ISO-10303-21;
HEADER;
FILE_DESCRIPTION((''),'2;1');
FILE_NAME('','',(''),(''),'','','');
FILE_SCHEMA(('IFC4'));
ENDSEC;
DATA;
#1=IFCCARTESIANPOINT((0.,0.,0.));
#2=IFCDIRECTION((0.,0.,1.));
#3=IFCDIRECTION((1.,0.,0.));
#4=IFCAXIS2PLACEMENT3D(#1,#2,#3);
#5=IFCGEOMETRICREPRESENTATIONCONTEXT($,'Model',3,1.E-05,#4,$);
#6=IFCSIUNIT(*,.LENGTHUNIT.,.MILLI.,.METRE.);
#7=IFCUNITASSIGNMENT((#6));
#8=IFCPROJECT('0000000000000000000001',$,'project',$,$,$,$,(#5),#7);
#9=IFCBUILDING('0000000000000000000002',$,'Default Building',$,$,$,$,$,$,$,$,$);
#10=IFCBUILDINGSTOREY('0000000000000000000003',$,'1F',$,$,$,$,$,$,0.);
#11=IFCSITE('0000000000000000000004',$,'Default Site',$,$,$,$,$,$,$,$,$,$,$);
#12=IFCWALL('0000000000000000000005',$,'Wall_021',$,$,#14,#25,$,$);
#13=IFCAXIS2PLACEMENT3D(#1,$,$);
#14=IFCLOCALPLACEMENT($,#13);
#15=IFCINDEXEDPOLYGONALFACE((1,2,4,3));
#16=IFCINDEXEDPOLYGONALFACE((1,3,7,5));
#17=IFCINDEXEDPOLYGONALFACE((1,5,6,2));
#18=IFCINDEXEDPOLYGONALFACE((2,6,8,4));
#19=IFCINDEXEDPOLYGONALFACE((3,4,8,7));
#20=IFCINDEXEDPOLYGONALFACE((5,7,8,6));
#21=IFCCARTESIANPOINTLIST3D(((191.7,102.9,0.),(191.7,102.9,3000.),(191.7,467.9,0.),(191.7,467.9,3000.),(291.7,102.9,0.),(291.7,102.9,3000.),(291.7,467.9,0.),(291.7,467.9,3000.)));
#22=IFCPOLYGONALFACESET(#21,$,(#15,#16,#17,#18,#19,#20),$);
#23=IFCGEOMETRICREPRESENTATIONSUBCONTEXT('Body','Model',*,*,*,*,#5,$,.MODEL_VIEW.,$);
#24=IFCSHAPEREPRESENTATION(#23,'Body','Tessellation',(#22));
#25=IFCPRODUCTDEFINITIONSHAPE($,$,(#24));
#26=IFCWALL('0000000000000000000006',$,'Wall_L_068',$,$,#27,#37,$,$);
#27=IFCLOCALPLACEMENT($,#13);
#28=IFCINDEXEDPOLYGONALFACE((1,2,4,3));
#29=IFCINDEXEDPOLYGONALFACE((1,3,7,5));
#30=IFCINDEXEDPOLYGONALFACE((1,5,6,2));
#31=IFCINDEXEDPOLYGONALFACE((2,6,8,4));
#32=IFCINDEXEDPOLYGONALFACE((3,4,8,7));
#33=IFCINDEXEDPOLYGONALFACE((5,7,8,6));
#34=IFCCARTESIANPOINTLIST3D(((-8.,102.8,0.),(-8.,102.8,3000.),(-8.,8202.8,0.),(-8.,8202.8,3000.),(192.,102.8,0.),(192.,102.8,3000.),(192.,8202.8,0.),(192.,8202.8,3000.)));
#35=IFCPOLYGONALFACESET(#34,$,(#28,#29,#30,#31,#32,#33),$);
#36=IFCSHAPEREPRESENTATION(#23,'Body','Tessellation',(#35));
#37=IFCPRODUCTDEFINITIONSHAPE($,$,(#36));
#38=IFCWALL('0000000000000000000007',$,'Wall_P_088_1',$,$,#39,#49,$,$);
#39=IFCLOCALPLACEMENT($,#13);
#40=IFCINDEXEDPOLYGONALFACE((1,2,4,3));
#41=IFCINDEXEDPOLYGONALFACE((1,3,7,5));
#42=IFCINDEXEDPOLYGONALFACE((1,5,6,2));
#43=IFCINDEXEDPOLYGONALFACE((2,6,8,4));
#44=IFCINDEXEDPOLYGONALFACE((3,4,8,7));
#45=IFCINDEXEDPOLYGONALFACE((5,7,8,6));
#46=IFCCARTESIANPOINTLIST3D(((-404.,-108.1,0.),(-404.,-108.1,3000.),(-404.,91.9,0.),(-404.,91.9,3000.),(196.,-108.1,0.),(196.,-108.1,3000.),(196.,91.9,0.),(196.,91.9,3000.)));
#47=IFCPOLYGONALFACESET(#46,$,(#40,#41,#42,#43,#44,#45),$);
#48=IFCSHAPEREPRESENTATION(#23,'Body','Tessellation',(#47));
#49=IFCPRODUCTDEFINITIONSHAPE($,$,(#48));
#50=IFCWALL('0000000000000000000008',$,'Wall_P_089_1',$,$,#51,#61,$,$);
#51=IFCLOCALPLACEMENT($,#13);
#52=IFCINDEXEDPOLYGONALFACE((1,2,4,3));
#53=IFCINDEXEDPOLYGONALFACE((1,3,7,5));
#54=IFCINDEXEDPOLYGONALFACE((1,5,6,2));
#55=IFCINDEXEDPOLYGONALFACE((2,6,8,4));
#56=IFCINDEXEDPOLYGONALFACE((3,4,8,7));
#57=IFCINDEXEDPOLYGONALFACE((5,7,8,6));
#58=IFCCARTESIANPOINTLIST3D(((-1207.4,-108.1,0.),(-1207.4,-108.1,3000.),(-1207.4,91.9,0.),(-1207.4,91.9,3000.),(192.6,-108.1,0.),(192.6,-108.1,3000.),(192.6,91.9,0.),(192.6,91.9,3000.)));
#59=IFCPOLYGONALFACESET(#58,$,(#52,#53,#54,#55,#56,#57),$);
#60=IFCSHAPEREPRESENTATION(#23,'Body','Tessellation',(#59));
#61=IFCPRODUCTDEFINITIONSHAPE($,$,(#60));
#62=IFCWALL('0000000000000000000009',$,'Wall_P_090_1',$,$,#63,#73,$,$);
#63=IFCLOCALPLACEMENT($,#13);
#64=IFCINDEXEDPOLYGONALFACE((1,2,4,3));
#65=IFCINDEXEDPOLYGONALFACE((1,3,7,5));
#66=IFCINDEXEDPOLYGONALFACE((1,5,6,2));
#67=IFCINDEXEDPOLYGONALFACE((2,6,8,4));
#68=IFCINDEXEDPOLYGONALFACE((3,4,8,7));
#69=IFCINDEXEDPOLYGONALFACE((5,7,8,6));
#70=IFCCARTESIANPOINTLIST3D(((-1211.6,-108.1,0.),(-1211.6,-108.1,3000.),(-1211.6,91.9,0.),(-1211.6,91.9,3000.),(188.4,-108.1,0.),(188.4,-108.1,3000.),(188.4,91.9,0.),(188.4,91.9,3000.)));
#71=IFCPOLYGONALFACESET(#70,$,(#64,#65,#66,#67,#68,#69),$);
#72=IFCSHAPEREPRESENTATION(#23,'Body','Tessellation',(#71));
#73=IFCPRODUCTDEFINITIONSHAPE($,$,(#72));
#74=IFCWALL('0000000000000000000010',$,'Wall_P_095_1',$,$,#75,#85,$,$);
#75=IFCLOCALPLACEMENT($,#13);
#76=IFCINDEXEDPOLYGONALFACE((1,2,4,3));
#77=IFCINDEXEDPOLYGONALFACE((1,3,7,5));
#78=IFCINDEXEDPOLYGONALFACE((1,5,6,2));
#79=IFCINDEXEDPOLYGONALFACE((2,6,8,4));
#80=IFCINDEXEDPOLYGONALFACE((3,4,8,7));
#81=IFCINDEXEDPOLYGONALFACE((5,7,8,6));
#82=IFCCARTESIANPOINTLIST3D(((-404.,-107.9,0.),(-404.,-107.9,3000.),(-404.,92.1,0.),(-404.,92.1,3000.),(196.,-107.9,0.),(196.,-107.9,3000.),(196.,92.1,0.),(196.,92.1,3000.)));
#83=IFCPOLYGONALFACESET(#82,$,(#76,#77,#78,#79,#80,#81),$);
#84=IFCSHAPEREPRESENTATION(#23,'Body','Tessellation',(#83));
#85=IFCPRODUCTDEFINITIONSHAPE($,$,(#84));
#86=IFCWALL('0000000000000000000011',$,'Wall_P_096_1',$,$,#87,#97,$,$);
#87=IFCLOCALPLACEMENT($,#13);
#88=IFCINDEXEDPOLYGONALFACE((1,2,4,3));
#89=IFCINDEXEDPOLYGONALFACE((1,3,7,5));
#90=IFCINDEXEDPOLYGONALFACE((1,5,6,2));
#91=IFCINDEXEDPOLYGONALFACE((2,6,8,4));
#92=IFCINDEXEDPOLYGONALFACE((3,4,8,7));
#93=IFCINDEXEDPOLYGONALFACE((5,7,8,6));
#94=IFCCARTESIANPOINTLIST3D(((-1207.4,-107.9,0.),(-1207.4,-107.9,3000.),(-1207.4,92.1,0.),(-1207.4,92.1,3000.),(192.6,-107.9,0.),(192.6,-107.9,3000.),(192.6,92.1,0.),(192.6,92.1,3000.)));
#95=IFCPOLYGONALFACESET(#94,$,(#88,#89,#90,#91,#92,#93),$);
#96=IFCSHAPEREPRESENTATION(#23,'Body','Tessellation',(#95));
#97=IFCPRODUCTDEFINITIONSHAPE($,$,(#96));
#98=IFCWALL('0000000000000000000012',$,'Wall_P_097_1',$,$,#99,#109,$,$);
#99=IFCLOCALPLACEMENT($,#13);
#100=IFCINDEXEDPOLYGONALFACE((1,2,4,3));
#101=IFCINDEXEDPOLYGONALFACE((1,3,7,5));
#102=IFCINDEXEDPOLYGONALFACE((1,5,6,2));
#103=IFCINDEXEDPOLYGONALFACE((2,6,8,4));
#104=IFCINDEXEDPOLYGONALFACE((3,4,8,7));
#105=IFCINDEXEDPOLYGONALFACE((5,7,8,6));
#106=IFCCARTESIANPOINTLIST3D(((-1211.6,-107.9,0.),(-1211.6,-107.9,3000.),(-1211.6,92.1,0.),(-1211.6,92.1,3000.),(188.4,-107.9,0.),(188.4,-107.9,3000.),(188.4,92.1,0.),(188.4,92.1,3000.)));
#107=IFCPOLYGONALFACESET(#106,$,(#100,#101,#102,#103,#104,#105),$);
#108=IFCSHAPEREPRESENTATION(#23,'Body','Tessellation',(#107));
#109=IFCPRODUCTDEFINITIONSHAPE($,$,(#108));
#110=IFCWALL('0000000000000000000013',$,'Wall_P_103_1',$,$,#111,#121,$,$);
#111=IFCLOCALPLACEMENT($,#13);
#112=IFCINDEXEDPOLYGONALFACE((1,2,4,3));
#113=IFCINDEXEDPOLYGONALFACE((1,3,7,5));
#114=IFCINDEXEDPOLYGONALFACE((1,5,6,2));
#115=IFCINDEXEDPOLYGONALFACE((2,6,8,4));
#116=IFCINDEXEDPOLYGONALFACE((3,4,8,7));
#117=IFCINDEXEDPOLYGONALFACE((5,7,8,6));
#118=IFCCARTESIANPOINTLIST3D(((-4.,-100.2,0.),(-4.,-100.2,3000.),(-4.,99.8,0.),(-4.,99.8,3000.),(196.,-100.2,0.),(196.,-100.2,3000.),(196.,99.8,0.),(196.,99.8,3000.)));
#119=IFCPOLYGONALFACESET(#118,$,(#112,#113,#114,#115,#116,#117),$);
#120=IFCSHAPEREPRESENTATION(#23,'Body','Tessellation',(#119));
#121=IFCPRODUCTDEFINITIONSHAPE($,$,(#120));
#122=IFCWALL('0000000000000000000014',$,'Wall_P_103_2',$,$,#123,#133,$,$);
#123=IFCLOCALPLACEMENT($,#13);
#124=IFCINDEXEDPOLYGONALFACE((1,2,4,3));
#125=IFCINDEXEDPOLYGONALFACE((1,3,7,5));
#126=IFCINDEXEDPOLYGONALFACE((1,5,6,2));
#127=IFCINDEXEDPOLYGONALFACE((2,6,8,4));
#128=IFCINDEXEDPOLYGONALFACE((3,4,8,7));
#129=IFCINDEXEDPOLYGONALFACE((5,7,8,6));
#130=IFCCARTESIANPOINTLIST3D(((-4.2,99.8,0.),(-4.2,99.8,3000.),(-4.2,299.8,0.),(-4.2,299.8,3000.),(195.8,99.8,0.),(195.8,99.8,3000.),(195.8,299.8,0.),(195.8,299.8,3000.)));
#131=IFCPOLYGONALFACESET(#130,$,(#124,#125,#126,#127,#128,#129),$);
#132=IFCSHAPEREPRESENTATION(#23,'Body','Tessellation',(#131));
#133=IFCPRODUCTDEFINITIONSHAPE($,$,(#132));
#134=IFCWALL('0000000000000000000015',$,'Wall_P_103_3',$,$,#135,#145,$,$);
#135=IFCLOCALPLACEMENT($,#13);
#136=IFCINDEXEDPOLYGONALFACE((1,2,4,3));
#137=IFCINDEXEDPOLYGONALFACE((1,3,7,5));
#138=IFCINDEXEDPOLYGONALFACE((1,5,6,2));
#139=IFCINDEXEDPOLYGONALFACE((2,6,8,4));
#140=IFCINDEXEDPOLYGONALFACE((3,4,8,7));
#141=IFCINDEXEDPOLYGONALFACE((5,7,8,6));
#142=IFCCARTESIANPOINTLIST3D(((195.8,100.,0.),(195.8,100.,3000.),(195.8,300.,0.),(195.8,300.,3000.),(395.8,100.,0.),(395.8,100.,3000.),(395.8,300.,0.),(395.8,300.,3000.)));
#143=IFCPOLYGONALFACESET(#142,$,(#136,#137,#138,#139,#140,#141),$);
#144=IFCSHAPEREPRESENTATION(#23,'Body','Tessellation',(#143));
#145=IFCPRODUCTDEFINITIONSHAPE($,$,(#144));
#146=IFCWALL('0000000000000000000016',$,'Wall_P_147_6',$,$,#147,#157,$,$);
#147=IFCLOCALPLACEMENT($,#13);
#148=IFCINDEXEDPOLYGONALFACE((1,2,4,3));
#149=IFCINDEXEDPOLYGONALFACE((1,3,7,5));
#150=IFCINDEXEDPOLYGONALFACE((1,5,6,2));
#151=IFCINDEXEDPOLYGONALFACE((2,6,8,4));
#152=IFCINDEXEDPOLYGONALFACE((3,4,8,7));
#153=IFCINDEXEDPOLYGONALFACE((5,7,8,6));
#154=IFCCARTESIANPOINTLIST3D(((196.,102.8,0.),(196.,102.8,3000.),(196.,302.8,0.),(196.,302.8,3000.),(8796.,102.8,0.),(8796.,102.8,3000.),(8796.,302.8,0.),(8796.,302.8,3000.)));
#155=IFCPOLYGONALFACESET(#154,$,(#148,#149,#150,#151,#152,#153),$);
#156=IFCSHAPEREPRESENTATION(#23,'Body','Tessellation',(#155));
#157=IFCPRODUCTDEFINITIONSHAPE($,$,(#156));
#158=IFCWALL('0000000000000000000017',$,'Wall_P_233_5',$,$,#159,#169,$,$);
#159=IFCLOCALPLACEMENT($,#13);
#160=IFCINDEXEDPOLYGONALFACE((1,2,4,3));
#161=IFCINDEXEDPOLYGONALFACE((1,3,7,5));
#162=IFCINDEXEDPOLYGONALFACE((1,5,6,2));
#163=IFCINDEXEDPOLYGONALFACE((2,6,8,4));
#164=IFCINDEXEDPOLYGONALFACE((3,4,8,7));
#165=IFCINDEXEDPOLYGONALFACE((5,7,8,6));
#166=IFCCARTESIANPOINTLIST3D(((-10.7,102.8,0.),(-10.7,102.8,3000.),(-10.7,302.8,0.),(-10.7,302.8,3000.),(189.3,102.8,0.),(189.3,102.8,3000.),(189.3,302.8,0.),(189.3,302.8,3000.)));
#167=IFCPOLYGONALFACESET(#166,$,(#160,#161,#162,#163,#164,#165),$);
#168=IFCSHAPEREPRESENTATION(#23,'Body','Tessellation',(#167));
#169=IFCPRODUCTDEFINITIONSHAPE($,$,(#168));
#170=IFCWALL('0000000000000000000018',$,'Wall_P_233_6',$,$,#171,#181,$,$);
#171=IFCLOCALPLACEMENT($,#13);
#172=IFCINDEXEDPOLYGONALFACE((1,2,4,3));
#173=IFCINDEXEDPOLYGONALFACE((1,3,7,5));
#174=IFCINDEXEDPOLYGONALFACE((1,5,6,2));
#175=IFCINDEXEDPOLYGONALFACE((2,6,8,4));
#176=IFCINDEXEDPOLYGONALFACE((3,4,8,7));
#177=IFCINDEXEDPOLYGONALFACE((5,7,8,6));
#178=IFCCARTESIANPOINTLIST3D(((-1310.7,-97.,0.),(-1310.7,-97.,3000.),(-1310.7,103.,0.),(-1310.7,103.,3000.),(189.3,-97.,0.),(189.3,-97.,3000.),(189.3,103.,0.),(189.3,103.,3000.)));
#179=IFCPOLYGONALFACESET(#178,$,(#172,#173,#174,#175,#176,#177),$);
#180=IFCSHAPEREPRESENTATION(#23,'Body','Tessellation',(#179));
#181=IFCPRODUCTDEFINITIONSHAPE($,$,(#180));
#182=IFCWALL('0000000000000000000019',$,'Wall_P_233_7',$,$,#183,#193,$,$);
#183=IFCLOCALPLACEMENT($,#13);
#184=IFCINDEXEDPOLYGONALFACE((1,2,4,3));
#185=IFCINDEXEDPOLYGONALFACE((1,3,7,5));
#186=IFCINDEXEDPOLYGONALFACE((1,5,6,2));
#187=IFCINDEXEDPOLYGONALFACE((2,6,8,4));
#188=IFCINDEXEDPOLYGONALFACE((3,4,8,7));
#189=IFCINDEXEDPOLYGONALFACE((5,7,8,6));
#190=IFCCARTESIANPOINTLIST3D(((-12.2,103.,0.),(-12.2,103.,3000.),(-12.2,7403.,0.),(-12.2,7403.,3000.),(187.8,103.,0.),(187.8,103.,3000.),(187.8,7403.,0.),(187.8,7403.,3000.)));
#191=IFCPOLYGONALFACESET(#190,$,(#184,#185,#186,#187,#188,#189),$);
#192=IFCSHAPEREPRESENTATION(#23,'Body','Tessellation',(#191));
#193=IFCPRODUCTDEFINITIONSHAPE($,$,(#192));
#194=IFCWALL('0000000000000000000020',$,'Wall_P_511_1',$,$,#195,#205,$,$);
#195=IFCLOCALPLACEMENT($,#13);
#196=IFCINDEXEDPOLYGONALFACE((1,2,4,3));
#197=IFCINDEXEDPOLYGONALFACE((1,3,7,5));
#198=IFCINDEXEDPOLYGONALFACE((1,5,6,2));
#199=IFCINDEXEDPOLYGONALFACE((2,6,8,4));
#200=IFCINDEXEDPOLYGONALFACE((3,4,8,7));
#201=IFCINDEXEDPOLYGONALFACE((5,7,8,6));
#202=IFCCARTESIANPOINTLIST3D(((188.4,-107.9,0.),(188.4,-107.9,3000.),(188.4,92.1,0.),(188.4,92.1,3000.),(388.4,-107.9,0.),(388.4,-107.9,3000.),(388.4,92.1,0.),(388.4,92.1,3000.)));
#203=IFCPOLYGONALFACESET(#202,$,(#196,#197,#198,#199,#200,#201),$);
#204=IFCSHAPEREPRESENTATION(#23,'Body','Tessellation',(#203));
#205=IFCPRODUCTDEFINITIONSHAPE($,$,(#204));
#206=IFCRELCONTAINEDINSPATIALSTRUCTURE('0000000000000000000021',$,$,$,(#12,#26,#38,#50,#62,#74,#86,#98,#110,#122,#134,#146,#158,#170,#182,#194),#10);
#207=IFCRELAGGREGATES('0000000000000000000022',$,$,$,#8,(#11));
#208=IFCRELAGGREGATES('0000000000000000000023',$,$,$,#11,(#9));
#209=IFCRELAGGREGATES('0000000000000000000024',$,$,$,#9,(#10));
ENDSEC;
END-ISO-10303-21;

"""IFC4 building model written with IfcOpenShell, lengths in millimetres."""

from ifc_helpers import new_model, si_unit, frame, origin_with_axes, place, context, subcontext, project, spatial, indexed_curve, outline, extrude, element, save


model = new_model("IFC4")

# Units and contexts
model_context = context("Model", 3, precision=1e-05, world=origin_with_axes())
body_context = subcontext(model_context, "Body", "Model", "MODEL_VIEW")
ifc_project = project(units=[si_unit("LENGTHUNIT", "METRE", prefix="MILLI")], contexts=[model_context])

# Site, building, storey
site = spatial("IfcSite", under=ifc_project, Name="Default Site")
building = spatial("IfcBuilding", under=site, Name="Default Building")
storey = spatial("IfcBuildingStorey", under=building, Name="1F", Elevation=0.0)

# Walls
wall_1_placement = place(None, frame((191.7, 102.9, 0.0), z_axis=(0.0, 0.0, 1.0), x_axis=(1.0, 0.0, 0.0)))
element("IfcWall", 1, at=wall_1_placement, inside=storey, Name="Wall_021", context=body_context, shape_type="SweptSolid", body=[
    extrude(outline(indexed_curve([(0.0, 0.0), (0.0, 365.0), (100.0, 365.0), (100.0, 0.0), (0.0, 0.0)], self_intersect=False)), origin_with_axes(), (0.0, 0.0, 1.0), 3000.0),
])
wall_2_placement = place(None, frame((192.0, 102.8, 0.0), z_axis=(0.0, 0.0, 1.0), x_axis=(0.0, 1.0, 0.0)))
element("IfcWall", 2, at=wall_2_placement, inside=storey, Name="Wall_L_068", context=body_context, shape_type="SweptSolid", body=[
    extrude(outline(indexed_curve([(0.0, 0.0), (0.0, 200.0), (8100.0, 200.0), (8100.0, 0.0), (0.0, 0.0)], self_intersect=False)), origin_with_axes(), (0.0, 0.0, 1.0), 3000.0),
])
wall_3_placement = place(None, frame((196.0, 91.9, 0.0), z_axis=(0.0, 0.0, 1.0), x_axis=(-1.0, 0.0, 0.0)))
element("IfcWall", 3, at=wall_3_placement, inside=storey, Name="Wall_P_088_1", context=body_context, shape_type="SweptSolid", body=[
    extrude(outline(indexed_curve([(0.0, 0.0), (0.0, 200.0), (600.0, 200.0), (600.0, 0.0), (0.0, 0.0)], self_intersect=False)), origin_with_axes(), (0.0, 0.0, 1.0), 3000.0),
])
for number, where, z_axis, x_axis, name in (
    (4, (192.6, 91.9, 0.0), (0.0, 0.0, 1.0), (-1.0, 0.0, 0.0), "Wall_P_089_1"),
    (5, (188.4, 91.9, 0.0), (0.0, 0.0, 1.0), (-1.0, 0.0, 0.0), "Wall_P_090_1"),
):
    element("IfcWall", number, at=place(None, frame(where, z_axis=z_axis, x_axis=x_axis)), inside=storey, Name=name, context=body_context, shape_type="SweptSolid", body=[
        extrude(outline(indexed_curve([(0.0, 0.0), (0.0, 200.0), (1400.0, 200.0), (1400.0, 0.0), (0.0, 0.0)], self_intersect=False)), origin_with_axes(), (0.0, 0.0, 1.0), 3000.0),
    ])
wall_4_placement = place(None, frame((196.0, 92.1, 0.0), z_axis=(0.0, 0.0, 1.0), x_axis=(-1.0, 0.0, 0.0)))
element("IfcWall", 6, at=wall_4_placement, inside=storey, Name="Wall_P_095_1", context=body_context, shape_type="SweptSolid", body=[
    extrude(outline(indexed_curve([(0.0, 0.0), (0.0, 200.0), (600.0, 200.0), (600.0, 0.0), (0.0, 0.0)], self_intersect=False)), origin_with_axes(), (0.0, 0.0, 1.0), 3000.0),
])
for number, where, z_axis, x_axis, name in (
    (7, (192.6, 92.1, 0.0), (0.0, 0.0, 1.0), (-1.0, 0.0, 0.0), "Wall_P_096_1"),
    (8, (188.4, 92.1, 0.0), (0.0, 0.0, 1.0), (-1.0, 0.0, 0.0), "Wall_P_097_1"),
):
    element("IfcWall", number, at=place(None, frame(where, z_axis=z_axis, x_axis=x_axis)), inside=storey, Name=name, context=body_context, shape_type="SweptSolid", body=[
        extrude(outline(indexed_curve([(0.0, 0.0), (0.0, 200.0), (1400.0, 200.0), (1400.0, 0.0), (0.0, 0.0)], self_intersect=False)), origin_with_axes(), (0.0, 0.0, 1.0), 3000.0),
    ])
wall_5_placement = place(None, frame((196.0, 99.8, 0.0), z_axis=(0.0, 0.0, 1.0), x_axis=(-1.0, 0.0, 0.0)))
element("IfcWall", 9, at=wall_5_placement, inside=storey, Name="Wall_P_103_1", context=body_context, shape_type="SweptSolid", body=[
    extrude(outline(indexed_curve([(0.0, 0.0), (0.0, 200.0), (200.0, 200.0), (200.0, 0.0), (0.0, 0.0)], self_intersect=False)), origin_with_axes(), (0.0, 0.0, 1.0), 3000.0),
])
wall_6_placement = place(None, frame((195.8, 99.8, 0.0), z_axis=(0.0, 0.0, 1.0), x_axis=(0.0, 1.0, 0.0)))
element("IfcWall", 10, at=wall_6_placement, inside=storey, Name="Wall_P_103_2", context=body_context, shape_type="SweptSolid", body=[
    extrude(outline(indexed_curve([(0.0, 0.0), (0.0, 200.0), (200.0, 200.0), (200.0, 0.0), (0.0, 0.0)], self_intersect=False)), origin_with_axes(), (0.0, 0.0, 1.0), 3000.0),
])
wall_7_placement = place(None, frame((195.8, 100.0, 0.0), z_axis=(0.0, 0.0, 1.0), x_axis=(1.0, 0.0, 0.0)))
element("IfcWall", 11, at=wall_7_placement, inside=storey, Name="Wall_P_103_3", context=body_context, shape_type="SweptSolid", body=[
    extrude(outline(indexed_curve([(0.0, 0.0), (0.0, 200.0), (200.0, 200.0), (200.0, 0.0), (0.0, 0.0)], self_intersect=False)), origin_with_axes(), (0.0, 0.0, 1.0), 3000.0),
])
wall_8_placement = place(None, frame((196.0, 102.8, 0.0), z_axis=(0.0, 0.0, 1.0), x_axis=(1.0, 0.0, 0.0)))
element("IfcWall", 12, at=wall_8_placement, inside=storey, Name="Wall_P_147_6", context=body_context, shape_type="SweptSolid", body=[
    extrude(outline(indexed_curve([(0.0, 0.0), (0.0, 200.0), (8600.0, 200.0), (8600.0, 0.0), (0.0, 0.0)], self_intersect=False)), origin_with_axes(), (0.0, 0.0, 1.0), 3000.0),
])
wall_9_placement = place(None, frame((189.3, 102.8, 0.0), z_axis=(0.0, 0.0, 1.0), x_axis=(0.0, 1.0, 0.0)))
element("IfcWall", 13, at=wall_9_placement, inside=storey, Name="Wall_P_233_5", context=body_context, shape_type="SweptSolid", body=[
    extrude(outline(indexed_curve([(0.0, 0.0), (0.0, 200.0), (200.0, 200.0), (200.0, 0.0), (0.0, 0.0)], self_intersect=False)), origin_with_axes(), (0.0, 0.0, 1.0), 3000.0),
])
wall_10_placement = place(None, frame((189.3, 103.0, 0.0), z_axis=(0.0, 0.0, 1.0), x_axis=(-1.0, 0.0, 0.0)))
element("IfcWall", 14, at=wall_10_placement, inside=storey, Name="Wall_P_233_6", context=body_context, shape_type="SweptSolid", body=[
    extrude(outline(indexed_curve([(0.0, 0.0), (0.0, 200.0), (1500.0, 200.0), (1500.0, 0.0), (0.0, 0.0)], self_intersect=False)), origin_with_axes(), (0.0, 0.0, 1.0), 3000.0),
])
wall_11_placement = place(None, frame((187.8, 103.0, 0.0), z_axis=(0.0, 0.0, 1.0), x_axis=(0.0, 1.0, 0.0)))
element("IfcWall", 15, at=wall_11_placement, inside=storey, Name="Wall_P_233_7", context=body_context, shape_type="SweptSolid", body=[
    extrude(outline(indexed_curve([(0.0, 0.0), (0.0, 200.0), (7300.0, 200.0), (7300.0, 0.0), (0.0, 0.0)], self_intersect=False)), origin_with_axes(), (0.0, 0.0, 1.0), 3000.0),
])
wall_12_placement = place(None, frame((188.4, 92.1, 0.0), z_axis=(0.0, 0.0, 1.0), x_axis=(0.0, -1.0, 0.0)))
element("IfcWall", 16, at=wall_12_placement, inside=storey, Name="Wall_P_511_1", context=body_context, shape_type="SweptSolid", body=[
    extrude(outline(indexed_curve([(0.0, 0.0), (0.0, 200.0), (200.0, 200.0), (200.0, 0.0), (0.0, 0.0)], self_intersect=False)), origin_with_axes(), (0.0, 0.0, 1.0), 3000.0),
])

save(model, "model.ifc")
